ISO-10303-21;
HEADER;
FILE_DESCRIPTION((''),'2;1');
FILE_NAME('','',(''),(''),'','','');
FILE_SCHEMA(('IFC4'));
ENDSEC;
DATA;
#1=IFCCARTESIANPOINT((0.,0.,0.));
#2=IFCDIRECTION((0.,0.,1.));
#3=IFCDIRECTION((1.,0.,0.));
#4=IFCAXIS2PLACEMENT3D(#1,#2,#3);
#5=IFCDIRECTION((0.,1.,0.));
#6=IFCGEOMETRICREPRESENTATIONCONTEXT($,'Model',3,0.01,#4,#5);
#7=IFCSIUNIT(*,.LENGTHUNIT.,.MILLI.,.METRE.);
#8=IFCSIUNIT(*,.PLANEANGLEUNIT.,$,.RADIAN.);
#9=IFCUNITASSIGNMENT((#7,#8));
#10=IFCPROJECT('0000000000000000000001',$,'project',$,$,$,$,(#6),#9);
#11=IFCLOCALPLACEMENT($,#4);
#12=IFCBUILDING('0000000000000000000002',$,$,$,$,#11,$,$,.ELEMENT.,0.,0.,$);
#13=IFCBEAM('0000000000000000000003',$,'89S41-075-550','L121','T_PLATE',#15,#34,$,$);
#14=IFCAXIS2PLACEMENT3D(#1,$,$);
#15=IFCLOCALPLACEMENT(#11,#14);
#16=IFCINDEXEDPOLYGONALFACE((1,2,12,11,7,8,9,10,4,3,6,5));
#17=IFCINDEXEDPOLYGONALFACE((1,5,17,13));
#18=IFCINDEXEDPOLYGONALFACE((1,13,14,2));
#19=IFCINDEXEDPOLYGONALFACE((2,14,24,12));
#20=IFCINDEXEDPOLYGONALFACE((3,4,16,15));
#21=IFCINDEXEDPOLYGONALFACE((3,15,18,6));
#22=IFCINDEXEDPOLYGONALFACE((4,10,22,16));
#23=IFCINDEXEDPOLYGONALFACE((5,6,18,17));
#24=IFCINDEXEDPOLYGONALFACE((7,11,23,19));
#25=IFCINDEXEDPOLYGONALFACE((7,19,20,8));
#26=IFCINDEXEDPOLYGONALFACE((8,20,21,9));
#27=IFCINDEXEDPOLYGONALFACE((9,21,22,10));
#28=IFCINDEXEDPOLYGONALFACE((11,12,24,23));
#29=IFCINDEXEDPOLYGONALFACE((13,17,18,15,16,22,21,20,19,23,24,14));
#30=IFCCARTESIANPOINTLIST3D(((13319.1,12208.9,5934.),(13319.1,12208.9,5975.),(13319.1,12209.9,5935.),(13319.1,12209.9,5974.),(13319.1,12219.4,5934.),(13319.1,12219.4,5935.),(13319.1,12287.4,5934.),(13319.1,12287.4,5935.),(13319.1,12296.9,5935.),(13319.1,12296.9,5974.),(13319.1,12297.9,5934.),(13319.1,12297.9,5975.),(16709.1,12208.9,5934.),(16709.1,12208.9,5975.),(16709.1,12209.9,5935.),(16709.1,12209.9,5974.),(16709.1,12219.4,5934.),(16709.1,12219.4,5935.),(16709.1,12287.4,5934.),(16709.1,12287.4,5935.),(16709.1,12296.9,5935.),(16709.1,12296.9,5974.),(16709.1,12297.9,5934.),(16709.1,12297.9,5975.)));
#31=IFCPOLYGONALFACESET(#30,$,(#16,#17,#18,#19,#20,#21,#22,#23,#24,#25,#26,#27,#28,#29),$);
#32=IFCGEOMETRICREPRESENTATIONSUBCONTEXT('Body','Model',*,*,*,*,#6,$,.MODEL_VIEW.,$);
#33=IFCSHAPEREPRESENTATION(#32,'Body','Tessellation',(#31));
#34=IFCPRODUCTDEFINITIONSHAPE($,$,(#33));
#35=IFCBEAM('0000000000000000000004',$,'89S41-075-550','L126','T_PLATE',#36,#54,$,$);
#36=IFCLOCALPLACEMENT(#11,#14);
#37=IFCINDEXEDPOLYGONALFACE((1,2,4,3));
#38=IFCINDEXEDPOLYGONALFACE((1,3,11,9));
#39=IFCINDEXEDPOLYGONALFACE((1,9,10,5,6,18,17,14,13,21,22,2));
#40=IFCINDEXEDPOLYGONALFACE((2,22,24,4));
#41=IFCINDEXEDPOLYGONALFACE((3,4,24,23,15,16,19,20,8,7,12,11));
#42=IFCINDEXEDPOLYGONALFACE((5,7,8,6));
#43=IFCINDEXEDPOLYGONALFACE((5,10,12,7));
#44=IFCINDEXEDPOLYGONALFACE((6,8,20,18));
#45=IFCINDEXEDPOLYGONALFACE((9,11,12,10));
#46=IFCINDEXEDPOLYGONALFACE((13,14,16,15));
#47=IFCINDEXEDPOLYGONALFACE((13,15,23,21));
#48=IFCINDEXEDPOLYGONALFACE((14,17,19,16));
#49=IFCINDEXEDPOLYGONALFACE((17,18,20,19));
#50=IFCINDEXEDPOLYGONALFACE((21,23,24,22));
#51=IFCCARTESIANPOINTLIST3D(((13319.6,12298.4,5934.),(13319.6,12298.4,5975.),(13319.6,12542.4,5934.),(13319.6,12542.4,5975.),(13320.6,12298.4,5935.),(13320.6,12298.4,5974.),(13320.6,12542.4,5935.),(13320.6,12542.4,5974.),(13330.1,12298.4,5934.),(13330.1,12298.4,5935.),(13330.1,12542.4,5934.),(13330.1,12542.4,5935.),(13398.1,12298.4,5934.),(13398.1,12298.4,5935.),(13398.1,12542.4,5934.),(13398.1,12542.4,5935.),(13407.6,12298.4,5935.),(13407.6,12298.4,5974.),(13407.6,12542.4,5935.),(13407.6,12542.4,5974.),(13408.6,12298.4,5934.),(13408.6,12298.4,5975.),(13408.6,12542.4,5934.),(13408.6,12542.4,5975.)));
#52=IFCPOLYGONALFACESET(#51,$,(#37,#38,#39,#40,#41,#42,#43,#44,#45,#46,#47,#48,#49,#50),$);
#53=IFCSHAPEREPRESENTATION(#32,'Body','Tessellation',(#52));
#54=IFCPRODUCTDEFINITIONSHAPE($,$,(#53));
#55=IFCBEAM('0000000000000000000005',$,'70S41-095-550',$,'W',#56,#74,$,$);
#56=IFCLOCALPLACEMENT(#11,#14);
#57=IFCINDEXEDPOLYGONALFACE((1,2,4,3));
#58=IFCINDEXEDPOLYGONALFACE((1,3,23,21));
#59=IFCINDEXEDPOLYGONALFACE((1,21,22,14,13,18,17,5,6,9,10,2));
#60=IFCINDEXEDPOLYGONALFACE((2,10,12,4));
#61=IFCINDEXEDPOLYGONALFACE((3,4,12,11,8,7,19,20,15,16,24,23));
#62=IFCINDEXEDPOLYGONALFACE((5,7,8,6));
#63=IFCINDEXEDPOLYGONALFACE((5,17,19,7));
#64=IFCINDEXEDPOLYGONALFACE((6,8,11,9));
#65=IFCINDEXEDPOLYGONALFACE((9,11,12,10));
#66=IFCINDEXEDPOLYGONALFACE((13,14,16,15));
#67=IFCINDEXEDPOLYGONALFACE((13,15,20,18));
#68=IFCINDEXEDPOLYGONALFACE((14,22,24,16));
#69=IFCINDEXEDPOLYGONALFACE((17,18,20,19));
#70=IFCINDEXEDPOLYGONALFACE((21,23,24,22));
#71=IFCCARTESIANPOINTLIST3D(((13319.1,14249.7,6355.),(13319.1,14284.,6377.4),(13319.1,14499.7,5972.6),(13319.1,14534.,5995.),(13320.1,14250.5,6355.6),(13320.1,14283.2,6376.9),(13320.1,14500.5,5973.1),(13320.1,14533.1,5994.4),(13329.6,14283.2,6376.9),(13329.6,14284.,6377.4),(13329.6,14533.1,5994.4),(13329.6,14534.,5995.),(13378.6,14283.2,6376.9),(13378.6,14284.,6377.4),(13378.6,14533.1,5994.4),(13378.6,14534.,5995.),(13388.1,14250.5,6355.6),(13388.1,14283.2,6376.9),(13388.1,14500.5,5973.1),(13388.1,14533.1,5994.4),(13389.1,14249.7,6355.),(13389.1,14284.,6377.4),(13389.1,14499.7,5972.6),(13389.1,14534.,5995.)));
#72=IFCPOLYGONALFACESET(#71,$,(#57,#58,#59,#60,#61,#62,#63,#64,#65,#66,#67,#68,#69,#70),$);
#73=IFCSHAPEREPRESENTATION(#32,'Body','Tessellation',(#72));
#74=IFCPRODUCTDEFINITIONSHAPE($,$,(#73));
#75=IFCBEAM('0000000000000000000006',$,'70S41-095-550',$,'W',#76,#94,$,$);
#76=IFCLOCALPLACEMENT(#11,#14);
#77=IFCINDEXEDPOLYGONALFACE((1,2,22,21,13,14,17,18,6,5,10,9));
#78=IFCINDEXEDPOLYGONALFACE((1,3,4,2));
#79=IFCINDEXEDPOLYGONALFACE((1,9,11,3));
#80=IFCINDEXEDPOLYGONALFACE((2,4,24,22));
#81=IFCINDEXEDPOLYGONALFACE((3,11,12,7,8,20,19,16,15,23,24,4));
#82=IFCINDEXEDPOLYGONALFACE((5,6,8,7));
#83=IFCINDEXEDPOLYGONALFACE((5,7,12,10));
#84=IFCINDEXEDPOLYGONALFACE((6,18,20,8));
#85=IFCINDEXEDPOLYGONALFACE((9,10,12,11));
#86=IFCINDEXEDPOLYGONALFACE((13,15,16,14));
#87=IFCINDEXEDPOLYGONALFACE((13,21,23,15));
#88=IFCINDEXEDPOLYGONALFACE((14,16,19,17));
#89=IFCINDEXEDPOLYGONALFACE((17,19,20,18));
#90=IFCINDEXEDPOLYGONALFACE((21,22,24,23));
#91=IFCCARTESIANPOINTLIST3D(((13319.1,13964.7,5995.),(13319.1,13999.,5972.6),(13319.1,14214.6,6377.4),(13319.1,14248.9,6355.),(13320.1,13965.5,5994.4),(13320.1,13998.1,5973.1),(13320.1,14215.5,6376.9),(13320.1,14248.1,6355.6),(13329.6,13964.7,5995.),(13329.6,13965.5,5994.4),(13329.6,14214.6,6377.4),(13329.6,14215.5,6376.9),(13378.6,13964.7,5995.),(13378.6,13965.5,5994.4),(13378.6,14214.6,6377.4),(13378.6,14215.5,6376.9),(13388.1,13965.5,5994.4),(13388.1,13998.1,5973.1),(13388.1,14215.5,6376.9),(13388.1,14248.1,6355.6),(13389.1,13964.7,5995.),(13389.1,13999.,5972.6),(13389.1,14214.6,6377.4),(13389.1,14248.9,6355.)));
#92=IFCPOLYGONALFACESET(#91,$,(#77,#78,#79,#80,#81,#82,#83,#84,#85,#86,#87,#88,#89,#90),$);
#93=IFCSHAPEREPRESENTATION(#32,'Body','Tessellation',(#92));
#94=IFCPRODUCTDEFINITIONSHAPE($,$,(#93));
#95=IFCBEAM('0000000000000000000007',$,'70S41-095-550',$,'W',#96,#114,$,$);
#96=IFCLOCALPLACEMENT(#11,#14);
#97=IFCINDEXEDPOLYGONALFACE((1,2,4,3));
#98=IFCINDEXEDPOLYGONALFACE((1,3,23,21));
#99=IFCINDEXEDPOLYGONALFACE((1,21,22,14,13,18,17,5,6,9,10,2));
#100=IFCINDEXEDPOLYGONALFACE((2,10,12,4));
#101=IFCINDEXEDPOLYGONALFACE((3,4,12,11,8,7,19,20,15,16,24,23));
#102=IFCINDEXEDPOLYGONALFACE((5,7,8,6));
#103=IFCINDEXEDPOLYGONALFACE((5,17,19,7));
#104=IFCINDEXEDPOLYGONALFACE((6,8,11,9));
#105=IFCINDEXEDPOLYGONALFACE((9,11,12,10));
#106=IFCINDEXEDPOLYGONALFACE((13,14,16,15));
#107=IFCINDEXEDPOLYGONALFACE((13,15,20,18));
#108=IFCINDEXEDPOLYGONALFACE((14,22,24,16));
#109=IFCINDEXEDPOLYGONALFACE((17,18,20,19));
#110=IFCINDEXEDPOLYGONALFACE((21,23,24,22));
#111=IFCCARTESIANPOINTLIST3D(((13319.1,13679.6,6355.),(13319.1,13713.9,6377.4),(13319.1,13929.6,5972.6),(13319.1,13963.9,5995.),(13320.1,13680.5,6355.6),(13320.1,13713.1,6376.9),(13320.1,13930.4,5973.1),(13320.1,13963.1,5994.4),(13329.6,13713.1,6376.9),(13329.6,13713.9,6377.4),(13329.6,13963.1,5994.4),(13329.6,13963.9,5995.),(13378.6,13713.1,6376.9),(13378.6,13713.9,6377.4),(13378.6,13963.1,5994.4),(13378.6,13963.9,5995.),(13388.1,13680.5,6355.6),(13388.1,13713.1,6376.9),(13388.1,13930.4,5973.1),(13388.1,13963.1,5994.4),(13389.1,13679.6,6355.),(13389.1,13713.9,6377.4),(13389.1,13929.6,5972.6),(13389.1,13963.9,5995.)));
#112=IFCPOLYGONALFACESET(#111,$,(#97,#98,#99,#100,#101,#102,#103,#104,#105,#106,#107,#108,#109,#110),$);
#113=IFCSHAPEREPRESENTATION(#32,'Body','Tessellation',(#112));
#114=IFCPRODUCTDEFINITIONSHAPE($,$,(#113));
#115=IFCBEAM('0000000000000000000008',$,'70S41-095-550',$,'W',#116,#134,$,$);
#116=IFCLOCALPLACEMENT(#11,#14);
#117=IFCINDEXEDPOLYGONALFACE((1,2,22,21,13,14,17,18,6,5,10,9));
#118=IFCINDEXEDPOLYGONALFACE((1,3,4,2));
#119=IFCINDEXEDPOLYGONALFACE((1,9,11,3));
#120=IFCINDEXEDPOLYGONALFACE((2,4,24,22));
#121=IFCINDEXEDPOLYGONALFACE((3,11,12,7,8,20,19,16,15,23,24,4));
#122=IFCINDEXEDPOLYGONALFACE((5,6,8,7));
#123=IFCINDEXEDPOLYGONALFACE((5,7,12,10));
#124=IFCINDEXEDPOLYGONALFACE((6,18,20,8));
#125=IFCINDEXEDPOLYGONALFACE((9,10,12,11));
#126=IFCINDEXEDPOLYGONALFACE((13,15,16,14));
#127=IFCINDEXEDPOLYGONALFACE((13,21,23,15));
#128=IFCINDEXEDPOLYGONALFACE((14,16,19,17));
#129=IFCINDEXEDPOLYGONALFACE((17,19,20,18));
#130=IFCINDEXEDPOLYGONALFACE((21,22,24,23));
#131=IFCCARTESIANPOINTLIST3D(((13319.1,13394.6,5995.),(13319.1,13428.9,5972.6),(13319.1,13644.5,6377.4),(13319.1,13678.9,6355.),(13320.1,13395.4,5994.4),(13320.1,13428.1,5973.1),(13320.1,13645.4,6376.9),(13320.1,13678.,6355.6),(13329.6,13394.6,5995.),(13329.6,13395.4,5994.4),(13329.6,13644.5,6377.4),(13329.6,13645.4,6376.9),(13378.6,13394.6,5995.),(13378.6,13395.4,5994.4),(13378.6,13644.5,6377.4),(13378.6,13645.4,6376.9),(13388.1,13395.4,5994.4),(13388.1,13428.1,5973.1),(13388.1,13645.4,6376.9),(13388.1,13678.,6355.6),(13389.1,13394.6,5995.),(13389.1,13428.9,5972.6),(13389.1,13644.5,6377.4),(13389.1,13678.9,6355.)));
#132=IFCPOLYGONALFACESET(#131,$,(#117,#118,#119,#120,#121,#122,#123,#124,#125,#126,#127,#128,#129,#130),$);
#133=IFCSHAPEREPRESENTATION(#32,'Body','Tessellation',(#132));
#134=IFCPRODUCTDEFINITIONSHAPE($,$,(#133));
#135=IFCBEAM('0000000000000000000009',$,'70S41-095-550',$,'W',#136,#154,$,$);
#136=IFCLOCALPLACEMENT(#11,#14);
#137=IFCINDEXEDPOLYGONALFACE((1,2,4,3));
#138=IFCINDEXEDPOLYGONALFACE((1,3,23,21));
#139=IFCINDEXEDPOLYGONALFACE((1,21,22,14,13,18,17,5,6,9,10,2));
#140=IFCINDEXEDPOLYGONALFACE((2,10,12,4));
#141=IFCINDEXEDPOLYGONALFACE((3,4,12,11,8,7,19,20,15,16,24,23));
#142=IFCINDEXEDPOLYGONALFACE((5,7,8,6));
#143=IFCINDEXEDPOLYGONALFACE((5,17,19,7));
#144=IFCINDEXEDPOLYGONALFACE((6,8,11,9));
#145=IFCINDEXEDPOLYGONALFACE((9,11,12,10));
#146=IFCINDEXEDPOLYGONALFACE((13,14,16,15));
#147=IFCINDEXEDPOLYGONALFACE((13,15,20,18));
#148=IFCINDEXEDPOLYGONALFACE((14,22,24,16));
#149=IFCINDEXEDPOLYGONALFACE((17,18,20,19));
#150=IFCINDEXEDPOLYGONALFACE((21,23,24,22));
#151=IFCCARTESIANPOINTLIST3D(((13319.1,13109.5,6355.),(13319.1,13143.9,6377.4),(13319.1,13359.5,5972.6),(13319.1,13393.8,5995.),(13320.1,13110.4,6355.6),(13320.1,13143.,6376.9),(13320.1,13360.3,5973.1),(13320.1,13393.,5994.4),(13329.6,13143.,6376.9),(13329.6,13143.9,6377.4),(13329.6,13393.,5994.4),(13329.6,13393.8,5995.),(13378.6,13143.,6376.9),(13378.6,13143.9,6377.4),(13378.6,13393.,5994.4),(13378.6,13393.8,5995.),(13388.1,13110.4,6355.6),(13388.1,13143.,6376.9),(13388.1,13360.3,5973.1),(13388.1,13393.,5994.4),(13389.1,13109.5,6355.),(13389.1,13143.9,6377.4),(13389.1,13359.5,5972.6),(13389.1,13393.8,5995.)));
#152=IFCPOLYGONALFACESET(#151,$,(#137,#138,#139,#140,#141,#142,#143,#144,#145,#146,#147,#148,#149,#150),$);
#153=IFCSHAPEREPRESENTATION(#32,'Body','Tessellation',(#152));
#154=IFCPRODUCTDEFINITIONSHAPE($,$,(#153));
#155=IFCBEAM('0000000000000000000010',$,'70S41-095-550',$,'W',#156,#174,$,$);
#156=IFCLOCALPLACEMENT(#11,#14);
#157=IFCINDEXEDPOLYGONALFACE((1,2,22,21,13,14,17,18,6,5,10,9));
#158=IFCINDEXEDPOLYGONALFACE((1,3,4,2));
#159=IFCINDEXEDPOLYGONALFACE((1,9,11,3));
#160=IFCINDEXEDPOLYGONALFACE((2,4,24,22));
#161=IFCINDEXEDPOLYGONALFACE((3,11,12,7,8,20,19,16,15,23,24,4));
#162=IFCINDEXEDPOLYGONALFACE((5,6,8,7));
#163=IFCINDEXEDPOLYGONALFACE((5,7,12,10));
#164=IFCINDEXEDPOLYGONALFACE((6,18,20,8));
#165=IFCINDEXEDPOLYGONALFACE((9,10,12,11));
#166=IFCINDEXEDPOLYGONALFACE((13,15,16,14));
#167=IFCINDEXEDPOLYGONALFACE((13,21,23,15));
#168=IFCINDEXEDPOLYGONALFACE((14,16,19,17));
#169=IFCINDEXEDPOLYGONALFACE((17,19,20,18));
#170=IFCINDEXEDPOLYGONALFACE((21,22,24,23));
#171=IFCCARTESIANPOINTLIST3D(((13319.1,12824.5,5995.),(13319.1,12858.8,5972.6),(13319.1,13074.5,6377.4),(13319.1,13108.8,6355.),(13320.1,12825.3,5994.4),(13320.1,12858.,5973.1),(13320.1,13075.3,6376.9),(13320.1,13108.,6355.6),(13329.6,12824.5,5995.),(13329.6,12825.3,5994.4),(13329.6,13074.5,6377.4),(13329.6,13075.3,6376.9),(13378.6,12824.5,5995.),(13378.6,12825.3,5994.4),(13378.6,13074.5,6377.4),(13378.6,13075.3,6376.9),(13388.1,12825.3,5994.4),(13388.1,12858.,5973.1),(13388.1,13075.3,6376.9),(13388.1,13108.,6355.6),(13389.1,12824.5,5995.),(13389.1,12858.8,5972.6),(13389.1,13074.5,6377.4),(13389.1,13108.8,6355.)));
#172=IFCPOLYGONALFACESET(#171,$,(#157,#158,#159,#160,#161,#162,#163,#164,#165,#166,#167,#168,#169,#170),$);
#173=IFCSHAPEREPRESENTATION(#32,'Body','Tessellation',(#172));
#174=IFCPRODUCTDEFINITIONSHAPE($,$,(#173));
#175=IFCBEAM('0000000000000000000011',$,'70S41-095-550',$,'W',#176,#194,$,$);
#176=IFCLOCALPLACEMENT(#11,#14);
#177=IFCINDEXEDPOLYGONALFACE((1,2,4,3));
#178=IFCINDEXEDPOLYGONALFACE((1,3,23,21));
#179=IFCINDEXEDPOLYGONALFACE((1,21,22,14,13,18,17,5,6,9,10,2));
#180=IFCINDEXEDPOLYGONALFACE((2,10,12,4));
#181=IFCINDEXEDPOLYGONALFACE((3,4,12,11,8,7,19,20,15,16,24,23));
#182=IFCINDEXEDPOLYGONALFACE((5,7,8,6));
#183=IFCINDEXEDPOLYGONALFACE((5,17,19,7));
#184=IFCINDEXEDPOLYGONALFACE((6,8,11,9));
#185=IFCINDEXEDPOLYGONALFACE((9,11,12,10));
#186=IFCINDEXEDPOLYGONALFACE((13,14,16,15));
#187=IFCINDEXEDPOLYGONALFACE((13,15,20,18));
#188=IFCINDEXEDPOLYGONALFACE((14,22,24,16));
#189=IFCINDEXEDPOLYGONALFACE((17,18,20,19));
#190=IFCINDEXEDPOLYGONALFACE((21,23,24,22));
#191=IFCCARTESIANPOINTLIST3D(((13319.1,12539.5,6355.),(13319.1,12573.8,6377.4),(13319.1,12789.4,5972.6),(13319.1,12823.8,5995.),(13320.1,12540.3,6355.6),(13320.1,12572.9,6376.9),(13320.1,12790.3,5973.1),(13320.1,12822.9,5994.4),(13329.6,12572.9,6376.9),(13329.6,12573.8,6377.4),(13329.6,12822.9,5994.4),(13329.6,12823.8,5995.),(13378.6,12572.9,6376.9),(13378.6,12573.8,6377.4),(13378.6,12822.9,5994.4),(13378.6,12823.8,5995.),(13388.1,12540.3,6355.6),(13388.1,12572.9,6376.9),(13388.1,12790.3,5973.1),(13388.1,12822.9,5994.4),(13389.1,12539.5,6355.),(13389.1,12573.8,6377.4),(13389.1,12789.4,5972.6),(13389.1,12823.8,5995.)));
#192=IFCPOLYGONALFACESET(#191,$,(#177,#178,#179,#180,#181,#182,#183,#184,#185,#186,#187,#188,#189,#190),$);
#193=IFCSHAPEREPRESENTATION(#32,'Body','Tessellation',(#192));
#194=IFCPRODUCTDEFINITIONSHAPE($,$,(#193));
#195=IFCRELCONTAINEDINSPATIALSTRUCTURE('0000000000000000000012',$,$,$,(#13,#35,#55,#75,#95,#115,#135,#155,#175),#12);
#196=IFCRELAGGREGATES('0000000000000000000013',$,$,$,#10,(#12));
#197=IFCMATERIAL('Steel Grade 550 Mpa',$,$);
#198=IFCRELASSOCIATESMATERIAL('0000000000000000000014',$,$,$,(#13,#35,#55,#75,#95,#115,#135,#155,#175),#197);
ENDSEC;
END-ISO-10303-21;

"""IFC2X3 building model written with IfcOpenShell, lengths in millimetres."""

from ifc_helpers import new_model, si_unit, direction, frame, origin, origin_with_axes, origin_2d_with_axis, place, context, subcontext, project, spatial, c_section, extrude, source, transform, mapped, material, element, save


model = new_model("IFC2X3")

# Units and contexts
model_context = context("Model", 3, precision=0.01, world=origin_with_axes(), true_north=direction((0.0, 1.0, 0.0)))
body_context = subcontext(model_context, "Body", "Model", "MODEL_VIEW")
ifc_project = project(units=[si_unit("LENGTHUNIT", "METRE", prefix="MILLI"), si_unit("PLANEANGLEUNIT", "RADIAN")], contexts=[model_context])

# Building
building_placement = place(None, origin_with_axes())
building = spatial("IfcBuilding", under=ifc_project, at=building_placement, CompositionType="ELEMENT", ElevationOfRefHeight=0.0, ElevationOfTerrain=0.0)

# Beams
ifc_material = material(Name="Steel Grade 550 Mpa")
shared_shape_1 = source(origin(), body_context, "Body", "SweptSolid", [
    extrude(c_section(Depth=89.0, Width=41.0, WallThickness=1.0, Girth=10.5, at=origin_2d_with_axis()), origin_with_axes(), (0.0, 0.0, 1.0), 3390.0),
])
beam_1_placement = place(None, frame((13319.1, 12253.4, 5954.5), z_axis=(1.0, 0.0, 0.0), x_axis=(0.0, 0.0, -1.0)))
element("IfcBeam", 1, at=beam_1_placement, inside=building, material=ifc_material, Name="89S41-075-550", Description="L121", ObjectType="T_PLATE", context=body_context, shape_type="MappedRepresentation", body=[
    mapped(shared_shape_1, transform((0.0, 0.0, 0.0), scale=1.0)),
])
shared_shape_2 = source(origin(), body_context, "Body", "SweptSolid", [
    extrude(c_section(Depth=89.0, Width=41.0, WallThickness=1.0, Girth=10.5, at=origin_2d_with_axis()), origin_with_axes(), (0.0, 0.0, 1.0), 244.0),
])
beam_2_placement = place(None, frame((13364.1, 12298.4, 5954.5), z_axis=(0.0, 1.0, 0.0), x_axis=(0.0, 0.0, -1.0)))
element("IfcBeam", 2, at=beam_2_placement, inside=building, material=ifc_material, Name="89S41-075-550", Description="L126", ObjectType="T_PLATE", context=body_context, shape_type="MappedRepresentation", body=[
    mapped(shared_shape_2, transform((0.0, 0.0, 0.0), scale=1.0)),
])
shared_shape_3 = source(origin(), body_context, "Body", "SweptSolid", [
    extrude(c_section(Depth=70.0, Width=41.0, WallThickness=1.0, Girth=10.5, at=origin_2d_with_axis()), origin_with_axes(), (0.0, 0.0, 1.0), 456.9),
])
beam_3_placement = place(None, frame((13354.1, 14266.9, 6366.2), z_axis=(0.0, 0.547116, -0.837057), x_axis=(0.0, 0.837057, 0.547116)))
element("IfcBeam", 3, at=beam_3_placement, inside=building, material=ifc_material, Name="70S41-095-550", ObjectType="W", context=body_context, shape_type="MappedRepresentation", body=[
    mapped(shared_shape_3, transform((0.0, 0.0, 0.0), scale=1.0)),
])
shared_shape_4 = source(origin(), body_context, "Body", "SweptSolid", [
    extrude(c_section(Depth=70.0, Width=41.0, WallThickness=1.0, Girth=10.5, at=origin_2d_with_axis()), origin_with_axes(), (0.0, 0.0, 1.0), 456.9),
])
beam_4_placement = place(None, frame((13354.1, 13981.8, 5983.8), z_axis=(0.0, 0.547116, 0.837057), x_axis=(0.0, -0.837057, 0.547116)))
element("IfcBeam", 4, at=beam_4_placement, inside=building, material=ifc_material, Name="70S41-095-550", ObjectType="W", context=body_context, shape_type="MappedRepresentation", body=[
    mapped(shared_shape_4, transform((0.0, 0.0, 0.0), scale=1.0)),
])
shared_shape_5 = source(origin(), body_context, "Body", "SweptSolid", [
    extrude(c_section(Depth=70.0, Width=41.0, WallThickness=1.0, Girth=10.5, at=origin_2d_with_axis()), origin_with_axes(), (0.0, 0.0, 1.0), 456.9),
])
beam_5_placement = place(None, frame((13354.1, 13696.8, 6366.2), z_axis=(0.0, 0.547116, -0.837057), x_axis=(0.0, 0.837057, 0.547116)))
element("IfcBeam", 5, at=beam_5_placement, inside=building, material=ifc_material, Name="70S41-095-550", ObjectType="W", context=body_context, shape_type="MappedRepresentation", body=[
    mapped(shared_shape_5, transform((0.0, 0.0, 0.0), scale=1.0)),
])
shared_shape_6 = source(origin(), body_context, "Body", "SweptSolid", [
    extrude(c_section(Depth=70.0, Width=41.0, WallThickness=1.0, Girth=10.5, at=origin_2d_with_axis()), origin_with_axes(), (0.0, 0.0, 1.0), 456.9),
])
beam_6_placement = place(None, frame((13354.1, 13411.7, 5983.8), z_axis=(0.0, 0.547116, 0.837057), x_axis=(0.0, -0.837057, 0.547116)))
element("IfcBeam", 6, at=beam_6_placement, inside=building, material=ifc_material, Name="70S41-095-550", ObjectType="W", context=body_context, shape_type="MappedRepresentation", body=[
    mapped(shared_shape_6, transform((0.0, 0.0, 0.0), scale=1.0)),
])
shared_shape_7 = source(origin(), body_context, "Body", "SweptSolid", [
    extrude(c_section(Depth=70.0, Width=41.0, WallThickness=1.0, Girth=10.5, at=origin_2d_with_axis()), origin_with_axes(), (0.0, 0.0, 1.0), 456.9),
])
beam_7_placement = place(None, frame((13354.1, 13126.7, 6366.2), z_axis=(0.0, 0.547116, -0.837057), x_axis=(0.0, 0.837057, 0.547116)))
element("IfcBeam", 7, at=beam_7_placement, inside=building, material=ifc_material, Name="70S41-095-550", ObjectType="W", context=body_context, shape_type="MappedRepresentation", body=[
    mapped(shared_shape_7, transform((0.0, 0.0, 0.0), scale=1.0)),
])
shared_shape_8 = source(origin(), body_context, "Body", "SweptSolid", [
    extrude(c_section(Depth=70.0, Width=41.0, WallThickness=1.0, Girth=10.5, at=origin_2d_with_axis()), origin_with_axes(), (0.0, 0.0, 1.0), 456.9),
])
beam_8_placement = place(None, frame((13354.1, 12841.7, 5983.8), z_axis=(0.0, 0.547116, 0.837057), x_axis=(0.0, -0.837057, 0.547116)))
element("IfcBeam", 8, at=beam_8_placement, inside=building, material=ifc_material, Name="70S41-095-550", ObjectType="W", context=body_context, shape_type="MappedRepresentation", body=[
    mapped(shared_shape_8, transform((0.0, 0.0, 0.0), scale=1.0)),
])
shared_shape_9 = source(origin(), body_context, "Body", "SweptSolid", [
    extrude(c_section(Depth=70.0, Width=41.0, WallThickness=1.0, Girth=10.5, at=origin_2d_with_axis()), origin_with_axes(), (0.0, 0.0, 1.0), 456.9),
])
beam_9_placement = place(None, frame((13354.1, 12556.6, 6366.2), z_axis=(0.0, 0.547116, -0.837057), x_axis=(0.0, 0.837057, 0.547116)))
element("IfcBeam", 9, at=beam_9_placement, inside=building, material=ifc_material, Name="70S41-095-550", ObjectType="W", context=body_context, shape_type="MappedRepresentation", body=[
    mapped(shared_shape_9, transform((0.0, 0.0, 0.0), scale=1.0)),
])

save(model, "model.ifc")
